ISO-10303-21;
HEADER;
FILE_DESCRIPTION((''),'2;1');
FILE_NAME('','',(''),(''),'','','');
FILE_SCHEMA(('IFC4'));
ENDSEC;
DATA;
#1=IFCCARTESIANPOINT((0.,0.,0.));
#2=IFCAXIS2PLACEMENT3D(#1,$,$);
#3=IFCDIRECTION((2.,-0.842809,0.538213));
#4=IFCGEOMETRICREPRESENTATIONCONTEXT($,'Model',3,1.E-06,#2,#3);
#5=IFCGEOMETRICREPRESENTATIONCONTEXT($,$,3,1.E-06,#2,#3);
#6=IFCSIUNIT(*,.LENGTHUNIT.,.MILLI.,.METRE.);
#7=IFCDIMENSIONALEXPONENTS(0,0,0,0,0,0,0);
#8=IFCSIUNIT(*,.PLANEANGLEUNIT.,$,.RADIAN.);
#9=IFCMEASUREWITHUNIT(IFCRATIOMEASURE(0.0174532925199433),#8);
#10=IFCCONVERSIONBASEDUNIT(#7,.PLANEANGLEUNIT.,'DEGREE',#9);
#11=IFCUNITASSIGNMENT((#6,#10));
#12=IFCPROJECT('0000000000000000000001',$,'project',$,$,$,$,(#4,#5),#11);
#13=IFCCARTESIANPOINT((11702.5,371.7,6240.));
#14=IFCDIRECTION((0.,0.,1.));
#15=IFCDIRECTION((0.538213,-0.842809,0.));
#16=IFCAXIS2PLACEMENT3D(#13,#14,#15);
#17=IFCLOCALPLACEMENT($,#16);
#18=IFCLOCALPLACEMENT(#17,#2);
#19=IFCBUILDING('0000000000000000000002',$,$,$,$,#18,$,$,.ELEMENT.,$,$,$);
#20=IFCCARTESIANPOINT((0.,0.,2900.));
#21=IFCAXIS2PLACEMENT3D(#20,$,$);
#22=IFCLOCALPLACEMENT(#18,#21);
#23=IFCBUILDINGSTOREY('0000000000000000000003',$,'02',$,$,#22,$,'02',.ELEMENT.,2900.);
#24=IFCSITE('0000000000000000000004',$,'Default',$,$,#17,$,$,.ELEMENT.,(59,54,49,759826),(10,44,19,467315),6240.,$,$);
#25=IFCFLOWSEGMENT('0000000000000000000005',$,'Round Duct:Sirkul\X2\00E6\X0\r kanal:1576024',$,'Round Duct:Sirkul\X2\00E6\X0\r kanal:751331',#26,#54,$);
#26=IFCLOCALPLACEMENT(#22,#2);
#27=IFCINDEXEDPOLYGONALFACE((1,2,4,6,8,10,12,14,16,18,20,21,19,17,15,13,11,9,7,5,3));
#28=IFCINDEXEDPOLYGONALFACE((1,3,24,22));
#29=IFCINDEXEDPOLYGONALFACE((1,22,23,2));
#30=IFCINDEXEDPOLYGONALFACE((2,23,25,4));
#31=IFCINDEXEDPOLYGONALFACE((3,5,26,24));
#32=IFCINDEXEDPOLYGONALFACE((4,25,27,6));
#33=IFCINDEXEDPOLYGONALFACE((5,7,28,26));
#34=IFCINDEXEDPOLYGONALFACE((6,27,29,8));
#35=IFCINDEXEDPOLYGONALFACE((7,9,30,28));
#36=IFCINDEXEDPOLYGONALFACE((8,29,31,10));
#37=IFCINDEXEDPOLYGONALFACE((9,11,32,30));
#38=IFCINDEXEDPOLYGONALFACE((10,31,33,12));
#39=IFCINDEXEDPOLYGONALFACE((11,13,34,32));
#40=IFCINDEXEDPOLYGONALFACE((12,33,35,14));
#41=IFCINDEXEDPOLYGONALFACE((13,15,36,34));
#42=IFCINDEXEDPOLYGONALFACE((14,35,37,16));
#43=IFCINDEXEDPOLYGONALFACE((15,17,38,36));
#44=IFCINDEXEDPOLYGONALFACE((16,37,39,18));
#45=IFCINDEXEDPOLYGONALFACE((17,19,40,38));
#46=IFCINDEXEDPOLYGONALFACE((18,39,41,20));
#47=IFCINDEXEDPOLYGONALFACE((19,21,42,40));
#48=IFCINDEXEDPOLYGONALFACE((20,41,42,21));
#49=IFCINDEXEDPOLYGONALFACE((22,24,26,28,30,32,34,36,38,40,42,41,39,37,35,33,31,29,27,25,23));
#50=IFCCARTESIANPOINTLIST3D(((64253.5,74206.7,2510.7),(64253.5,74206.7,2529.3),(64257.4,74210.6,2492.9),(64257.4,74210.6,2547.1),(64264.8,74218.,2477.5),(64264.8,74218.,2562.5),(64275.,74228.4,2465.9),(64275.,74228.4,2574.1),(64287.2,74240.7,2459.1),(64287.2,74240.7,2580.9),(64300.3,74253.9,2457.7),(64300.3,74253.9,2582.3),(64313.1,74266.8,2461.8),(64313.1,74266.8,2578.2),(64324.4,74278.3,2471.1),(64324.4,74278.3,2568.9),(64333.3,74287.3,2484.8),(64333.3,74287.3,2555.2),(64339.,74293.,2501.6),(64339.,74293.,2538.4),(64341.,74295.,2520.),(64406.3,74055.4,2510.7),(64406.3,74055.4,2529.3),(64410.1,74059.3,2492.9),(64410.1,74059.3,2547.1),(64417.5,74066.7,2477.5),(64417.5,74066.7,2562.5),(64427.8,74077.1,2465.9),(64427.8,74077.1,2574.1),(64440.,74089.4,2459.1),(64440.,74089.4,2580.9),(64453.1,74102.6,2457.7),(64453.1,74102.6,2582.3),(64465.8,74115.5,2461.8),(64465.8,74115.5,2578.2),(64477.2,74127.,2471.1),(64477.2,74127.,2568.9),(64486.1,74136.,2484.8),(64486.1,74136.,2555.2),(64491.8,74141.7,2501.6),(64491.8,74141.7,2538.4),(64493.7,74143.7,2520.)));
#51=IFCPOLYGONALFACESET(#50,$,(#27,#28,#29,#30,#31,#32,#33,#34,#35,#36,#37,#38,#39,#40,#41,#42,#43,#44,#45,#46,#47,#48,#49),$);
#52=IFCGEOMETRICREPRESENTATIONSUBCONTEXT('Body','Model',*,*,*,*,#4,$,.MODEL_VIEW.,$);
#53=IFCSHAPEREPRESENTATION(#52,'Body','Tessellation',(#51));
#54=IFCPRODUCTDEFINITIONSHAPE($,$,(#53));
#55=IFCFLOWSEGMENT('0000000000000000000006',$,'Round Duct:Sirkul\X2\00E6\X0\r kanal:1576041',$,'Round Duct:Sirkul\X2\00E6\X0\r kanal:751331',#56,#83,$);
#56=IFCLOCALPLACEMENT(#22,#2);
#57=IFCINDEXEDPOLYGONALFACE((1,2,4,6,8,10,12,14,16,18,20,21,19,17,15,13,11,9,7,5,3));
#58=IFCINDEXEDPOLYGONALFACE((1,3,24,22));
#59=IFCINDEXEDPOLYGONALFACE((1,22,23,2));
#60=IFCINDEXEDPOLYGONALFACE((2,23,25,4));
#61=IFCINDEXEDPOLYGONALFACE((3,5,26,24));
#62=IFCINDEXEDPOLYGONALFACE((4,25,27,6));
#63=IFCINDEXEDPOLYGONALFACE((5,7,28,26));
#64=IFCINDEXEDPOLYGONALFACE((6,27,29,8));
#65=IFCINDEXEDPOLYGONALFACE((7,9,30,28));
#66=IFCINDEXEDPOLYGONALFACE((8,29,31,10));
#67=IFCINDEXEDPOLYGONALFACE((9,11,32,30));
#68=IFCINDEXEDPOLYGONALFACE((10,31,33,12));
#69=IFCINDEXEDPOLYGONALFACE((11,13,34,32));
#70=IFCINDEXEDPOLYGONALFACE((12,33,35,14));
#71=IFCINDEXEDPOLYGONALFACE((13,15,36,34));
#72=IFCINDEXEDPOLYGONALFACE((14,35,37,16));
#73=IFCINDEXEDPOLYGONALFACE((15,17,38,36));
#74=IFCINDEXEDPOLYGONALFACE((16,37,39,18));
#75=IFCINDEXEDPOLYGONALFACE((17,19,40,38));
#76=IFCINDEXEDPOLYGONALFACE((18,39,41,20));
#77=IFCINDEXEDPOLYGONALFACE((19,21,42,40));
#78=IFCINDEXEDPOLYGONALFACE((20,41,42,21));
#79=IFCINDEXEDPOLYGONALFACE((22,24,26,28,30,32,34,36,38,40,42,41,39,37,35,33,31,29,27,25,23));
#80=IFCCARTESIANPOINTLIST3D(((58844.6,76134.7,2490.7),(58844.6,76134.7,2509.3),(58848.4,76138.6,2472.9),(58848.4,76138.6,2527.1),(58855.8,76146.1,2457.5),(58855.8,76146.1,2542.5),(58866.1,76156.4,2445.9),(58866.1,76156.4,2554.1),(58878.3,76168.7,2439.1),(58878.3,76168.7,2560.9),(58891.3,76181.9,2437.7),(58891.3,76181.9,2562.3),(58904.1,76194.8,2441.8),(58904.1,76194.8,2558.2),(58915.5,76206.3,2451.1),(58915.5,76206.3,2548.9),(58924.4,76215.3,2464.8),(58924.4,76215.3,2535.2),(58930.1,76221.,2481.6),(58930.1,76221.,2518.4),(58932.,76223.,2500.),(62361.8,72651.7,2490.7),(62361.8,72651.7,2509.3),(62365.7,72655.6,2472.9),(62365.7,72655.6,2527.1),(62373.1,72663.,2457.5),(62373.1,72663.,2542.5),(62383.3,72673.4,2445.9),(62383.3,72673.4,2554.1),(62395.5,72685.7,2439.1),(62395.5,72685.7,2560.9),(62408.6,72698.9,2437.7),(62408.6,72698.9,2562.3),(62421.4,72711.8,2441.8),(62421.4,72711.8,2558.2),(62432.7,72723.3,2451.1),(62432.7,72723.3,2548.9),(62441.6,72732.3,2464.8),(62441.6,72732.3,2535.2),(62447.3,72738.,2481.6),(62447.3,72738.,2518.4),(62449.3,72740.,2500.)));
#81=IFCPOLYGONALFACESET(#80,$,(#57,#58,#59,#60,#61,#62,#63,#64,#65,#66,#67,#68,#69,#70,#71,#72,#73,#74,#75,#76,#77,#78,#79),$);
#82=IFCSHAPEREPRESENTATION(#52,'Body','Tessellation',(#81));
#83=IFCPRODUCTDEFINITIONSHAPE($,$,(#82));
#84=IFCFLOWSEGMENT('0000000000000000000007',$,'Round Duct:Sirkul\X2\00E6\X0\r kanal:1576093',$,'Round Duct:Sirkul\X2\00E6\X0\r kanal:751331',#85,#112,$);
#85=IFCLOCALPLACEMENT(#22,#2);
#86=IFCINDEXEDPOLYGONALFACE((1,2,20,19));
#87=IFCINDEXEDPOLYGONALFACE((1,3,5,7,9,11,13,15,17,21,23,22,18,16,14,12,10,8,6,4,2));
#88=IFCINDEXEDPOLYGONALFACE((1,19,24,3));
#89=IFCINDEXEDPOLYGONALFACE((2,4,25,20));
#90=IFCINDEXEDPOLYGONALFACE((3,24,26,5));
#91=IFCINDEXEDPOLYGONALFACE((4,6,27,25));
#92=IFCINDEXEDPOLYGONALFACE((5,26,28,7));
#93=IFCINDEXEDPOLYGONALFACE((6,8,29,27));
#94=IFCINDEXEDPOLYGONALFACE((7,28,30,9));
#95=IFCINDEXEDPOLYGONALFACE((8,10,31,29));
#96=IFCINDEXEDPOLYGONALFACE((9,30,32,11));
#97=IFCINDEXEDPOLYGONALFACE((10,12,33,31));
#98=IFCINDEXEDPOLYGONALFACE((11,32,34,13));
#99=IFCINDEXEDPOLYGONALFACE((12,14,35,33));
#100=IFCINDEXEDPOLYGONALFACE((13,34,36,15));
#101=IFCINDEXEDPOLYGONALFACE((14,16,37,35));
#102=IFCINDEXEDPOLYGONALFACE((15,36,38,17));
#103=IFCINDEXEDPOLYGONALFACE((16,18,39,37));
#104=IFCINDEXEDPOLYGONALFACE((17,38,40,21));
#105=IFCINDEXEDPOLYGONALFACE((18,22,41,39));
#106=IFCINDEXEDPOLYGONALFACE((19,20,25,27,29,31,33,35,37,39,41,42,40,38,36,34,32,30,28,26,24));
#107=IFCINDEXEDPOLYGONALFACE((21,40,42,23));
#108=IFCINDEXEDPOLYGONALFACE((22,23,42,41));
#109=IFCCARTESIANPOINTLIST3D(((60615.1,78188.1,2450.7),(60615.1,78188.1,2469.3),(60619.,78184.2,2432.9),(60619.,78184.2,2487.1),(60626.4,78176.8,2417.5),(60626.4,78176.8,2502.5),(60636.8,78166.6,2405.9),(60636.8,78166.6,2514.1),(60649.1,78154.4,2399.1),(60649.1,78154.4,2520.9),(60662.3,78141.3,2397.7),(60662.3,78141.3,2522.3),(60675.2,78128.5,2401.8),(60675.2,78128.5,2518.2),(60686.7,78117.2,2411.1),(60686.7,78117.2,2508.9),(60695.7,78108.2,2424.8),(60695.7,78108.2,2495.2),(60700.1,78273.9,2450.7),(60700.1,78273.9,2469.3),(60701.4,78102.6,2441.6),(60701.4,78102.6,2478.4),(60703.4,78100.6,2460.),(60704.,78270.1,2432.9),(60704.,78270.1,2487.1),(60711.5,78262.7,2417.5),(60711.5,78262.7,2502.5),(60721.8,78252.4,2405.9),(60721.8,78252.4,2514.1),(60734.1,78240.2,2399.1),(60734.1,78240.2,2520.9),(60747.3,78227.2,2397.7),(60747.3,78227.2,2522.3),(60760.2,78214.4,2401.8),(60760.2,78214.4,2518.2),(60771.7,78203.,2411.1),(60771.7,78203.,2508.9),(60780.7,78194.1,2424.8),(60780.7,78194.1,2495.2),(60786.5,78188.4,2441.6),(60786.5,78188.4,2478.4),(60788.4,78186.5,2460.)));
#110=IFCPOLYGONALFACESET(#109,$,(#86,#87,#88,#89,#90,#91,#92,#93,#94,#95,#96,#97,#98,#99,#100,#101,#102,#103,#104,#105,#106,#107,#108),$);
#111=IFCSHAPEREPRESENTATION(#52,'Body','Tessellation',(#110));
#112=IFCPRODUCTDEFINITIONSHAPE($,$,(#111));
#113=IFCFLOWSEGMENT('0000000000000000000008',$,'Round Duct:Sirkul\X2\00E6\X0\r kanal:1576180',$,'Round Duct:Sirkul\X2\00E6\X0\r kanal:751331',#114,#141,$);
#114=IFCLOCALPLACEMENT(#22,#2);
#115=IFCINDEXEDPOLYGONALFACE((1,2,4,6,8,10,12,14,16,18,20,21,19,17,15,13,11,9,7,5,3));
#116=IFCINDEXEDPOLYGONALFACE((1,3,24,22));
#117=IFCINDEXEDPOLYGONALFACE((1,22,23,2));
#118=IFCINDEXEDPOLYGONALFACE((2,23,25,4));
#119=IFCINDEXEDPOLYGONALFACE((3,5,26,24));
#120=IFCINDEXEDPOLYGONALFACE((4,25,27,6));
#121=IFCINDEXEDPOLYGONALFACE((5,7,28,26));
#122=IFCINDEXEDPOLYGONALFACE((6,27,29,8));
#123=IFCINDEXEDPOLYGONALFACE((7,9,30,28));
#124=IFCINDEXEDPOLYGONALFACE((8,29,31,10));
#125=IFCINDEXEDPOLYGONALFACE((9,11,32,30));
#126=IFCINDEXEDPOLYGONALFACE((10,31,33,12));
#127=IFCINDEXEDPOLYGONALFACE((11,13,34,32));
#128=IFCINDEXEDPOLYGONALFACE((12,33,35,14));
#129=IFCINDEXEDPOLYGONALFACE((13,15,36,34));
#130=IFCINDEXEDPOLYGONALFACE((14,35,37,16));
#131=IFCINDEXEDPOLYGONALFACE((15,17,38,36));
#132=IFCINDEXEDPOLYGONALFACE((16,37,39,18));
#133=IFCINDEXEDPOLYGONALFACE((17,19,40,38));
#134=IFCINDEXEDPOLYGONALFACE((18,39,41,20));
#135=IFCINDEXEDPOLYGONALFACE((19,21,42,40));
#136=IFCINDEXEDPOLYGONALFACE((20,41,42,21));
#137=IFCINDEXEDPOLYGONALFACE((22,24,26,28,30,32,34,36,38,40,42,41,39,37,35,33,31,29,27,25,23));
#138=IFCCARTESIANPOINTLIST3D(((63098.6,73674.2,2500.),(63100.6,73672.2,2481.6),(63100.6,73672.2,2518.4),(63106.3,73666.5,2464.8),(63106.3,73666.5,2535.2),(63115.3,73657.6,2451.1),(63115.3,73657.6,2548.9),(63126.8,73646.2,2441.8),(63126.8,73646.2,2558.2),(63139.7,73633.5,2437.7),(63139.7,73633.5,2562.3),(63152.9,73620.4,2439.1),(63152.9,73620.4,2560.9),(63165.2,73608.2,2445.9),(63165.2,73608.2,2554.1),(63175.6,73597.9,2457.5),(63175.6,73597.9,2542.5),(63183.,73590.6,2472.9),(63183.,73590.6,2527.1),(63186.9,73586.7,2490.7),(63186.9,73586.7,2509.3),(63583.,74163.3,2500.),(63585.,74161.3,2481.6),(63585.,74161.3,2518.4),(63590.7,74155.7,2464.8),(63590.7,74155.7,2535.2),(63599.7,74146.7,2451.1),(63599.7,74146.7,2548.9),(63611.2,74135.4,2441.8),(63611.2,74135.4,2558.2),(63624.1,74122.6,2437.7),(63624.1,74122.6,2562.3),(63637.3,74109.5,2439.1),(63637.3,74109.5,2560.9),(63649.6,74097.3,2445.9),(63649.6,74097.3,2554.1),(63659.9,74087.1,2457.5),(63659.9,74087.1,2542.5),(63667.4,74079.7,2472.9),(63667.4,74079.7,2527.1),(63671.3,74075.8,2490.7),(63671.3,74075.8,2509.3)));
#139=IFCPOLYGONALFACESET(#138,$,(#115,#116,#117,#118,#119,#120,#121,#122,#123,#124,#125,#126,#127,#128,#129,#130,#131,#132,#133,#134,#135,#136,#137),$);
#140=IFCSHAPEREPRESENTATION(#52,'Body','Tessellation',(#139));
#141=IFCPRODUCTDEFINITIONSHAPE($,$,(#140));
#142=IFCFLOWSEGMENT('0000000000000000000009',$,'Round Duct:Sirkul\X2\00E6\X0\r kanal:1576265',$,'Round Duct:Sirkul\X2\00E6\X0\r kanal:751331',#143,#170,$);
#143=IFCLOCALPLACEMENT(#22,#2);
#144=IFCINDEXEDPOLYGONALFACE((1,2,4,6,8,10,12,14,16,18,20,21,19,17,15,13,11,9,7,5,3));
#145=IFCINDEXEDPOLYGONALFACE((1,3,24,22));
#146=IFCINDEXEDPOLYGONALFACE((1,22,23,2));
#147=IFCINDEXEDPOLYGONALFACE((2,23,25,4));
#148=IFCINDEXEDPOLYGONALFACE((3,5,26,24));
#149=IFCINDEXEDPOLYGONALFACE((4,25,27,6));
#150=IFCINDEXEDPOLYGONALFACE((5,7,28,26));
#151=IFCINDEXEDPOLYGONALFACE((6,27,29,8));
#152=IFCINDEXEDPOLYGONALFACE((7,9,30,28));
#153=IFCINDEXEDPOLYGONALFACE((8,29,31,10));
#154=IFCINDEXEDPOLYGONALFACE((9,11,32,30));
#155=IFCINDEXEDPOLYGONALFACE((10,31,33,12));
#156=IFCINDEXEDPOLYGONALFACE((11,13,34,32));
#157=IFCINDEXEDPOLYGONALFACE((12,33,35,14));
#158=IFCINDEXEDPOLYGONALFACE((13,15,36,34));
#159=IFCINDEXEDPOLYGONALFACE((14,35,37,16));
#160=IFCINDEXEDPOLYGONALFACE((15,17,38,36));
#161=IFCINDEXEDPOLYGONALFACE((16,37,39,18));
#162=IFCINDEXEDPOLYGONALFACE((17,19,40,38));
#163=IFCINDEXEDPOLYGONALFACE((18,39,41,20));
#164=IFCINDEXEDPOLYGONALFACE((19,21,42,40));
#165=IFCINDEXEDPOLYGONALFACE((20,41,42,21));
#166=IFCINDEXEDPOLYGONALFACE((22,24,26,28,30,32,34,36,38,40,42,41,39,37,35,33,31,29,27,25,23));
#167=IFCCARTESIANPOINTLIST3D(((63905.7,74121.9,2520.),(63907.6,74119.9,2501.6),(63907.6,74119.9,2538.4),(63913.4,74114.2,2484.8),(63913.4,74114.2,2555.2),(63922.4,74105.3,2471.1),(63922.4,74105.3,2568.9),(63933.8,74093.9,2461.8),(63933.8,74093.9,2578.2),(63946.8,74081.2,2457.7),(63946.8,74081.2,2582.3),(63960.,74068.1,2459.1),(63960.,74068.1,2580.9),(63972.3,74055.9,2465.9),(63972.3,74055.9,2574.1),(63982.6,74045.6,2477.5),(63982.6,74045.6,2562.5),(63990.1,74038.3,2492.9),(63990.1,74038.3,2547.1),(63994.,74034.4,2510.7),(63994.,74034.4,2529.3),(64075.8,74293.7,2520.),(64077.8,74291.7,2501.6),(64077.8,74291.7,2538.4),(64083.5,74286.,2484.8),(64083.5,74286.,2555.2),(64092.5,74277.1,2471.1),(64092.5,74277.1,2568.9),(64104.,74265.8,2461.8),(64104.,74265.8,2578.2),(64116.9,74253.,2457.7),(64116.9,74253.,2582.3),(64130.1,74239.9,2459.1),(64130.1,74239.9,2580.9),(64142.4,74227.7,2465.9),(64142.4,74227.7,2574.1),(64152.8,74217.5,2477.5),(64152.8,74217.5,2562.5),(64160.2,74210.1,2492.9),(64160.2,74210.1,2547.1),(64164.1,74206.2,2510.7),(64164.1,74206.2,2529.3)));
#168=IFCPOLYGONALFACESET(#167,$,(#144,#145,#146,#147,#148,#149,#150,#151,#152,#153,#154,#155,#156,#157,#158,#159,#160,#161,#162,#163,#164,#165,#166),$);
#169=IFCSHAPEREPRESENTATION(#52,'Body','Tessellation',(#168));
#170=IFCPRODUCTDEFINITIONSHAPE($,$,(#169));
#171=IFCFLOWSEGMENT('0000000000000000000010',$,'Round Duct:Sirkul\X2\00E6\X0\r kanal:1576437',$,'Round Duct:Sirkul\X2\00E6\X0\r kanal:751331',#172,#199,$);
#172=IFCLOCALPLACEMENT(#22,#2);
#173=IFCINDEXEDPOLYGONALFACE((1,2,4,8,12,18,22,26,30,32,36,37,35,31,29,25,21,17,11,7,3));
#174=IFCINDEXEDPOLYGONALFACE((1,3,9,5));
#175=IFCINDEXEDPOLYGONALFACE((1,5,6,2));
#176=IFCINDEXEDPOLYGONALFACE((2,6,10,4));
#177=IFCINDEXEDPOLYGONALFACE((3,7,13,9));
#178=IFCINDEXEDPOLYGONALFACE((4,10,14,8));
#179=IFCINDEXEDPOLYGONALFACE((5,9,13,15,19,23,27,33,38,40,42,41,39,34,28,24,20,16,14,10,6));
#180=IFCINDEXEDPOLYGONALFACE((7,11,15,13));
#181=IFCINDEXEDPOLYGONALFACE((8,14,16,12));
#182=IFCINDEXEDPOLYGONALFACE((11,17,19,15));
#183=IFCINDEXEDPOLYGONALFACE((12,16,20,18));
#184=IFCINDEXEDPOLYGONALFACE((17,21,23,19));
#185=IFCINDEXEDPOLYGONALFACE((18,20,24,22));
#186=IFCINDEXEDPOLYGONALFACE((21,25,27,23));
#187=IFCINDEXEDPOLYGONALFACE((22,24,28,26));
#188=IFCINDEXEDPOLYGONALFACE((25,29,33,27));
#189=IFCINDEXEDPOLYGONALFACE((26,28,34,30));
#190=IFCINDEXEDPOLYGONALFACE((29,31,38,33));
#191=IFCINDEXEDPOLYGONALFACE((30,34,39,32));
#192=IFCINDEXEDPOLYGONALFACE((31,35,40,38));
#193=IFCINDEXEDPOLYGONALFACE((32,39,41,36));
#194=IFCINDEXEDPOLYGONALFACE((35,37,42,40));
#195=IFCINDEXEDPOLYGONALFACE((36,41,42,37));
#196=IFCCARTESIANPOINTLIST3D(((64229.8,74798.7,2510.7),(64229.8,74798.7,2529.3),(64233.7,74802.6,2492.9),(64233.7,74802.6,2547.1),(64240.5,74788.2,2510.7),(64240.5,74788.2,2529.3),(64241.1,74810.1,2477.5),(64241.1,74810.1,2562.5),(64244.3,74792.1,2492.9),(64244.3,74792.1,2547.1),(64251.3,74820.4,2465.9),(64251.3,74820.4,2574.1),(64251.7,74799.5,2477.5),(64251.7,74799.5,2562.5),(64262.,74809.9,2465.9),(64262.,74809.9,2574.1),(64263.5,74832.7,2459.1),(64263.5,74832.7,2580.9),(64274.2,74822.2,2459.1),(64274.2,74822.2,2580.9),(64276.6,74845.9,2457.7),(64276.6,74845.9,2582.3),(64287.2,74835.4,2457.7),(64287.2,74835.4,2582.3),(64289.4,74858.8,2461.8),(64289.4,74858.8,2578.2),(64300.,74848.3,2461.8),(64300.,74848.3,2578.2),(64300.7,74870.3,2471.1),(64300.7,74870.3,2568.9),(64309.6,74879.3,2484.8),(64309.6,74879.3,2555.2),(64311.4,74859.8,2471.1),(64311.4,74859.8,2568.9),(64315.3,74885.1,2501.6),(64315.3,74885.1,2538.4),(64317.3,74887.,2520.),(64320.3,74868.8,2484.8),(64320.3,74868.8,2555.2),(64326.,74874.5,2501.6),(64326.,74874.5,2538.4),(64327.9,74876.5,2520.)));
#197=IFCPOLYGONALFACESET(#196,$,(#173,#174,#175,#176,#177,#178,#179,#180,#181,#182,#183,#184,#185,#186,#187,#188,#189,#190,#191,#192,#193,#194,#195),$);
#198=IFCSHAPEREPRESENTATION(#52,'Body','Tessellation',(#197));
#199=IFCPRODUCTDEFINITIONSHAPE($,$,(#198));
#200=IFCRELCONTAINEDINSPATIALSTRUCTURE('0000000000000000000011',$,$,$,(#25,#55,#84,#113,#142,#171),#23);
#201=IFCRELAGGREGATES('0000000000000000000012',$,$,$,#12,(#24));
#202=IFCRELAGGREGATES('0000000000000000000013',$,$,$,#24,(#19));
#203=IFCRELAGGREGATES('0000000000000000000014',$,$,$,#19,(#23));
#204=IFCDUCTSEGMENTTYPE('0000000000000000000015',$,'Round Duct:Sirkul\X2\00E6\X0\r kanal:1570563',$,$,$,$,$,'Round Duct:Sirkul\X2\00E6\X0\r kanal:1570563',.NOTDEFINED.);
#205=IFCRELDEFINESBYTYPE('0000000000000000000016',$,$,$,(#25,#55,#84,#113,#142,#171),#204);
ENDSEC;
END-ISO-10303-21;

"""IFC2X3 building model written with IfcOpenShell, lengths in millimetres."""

from ifc_helpers import new_model, entity, si_unit, converted_unit, direction, frame, origin, origin_2d_with_axis, place, context, subcontext, project, spatial, circle, extrude, type_object, element, save


model = new_model("IFC2X3")

# Units and contexts
model_context = context("Model", 3, precision=1e-06, world=origin(), true_north=direction((2.0, -0.842809, 0.538213)))
context_of_model = context(None, 3, precision=1e-06, world=origin(), true_north=direction((2.0, -0.842809, 0.538213)))
body_context = subcontext(model_context, "Body", "Model", "MODEL_VIEW")
ifc_project = project(units=[si_unit("LENGTHUNIT", "METRE", prefix="MILLI"), converted_unit("PLANEANGLEUNIT", "DEGREE", entity("IfcRatioMeasure", 0.0174532925199433), si_unit("PLANEANGLEUNIT", "RADIAN"), dimensions=[0, 0, 0, 0, 0, 0, 0])], contexts=[model_context, context_of_model])

# Site, building, storey
site_placement = place(None, frame((11702.5, 371.7, 6240.0), z_axis=(0.0, 0.0, 1.0), x_axis=(0.538213, -0.842809, 0.0)))
site = spatial("IfcSite", under=ifc_project, at=site_placement, Name="Default", CompositionType="ELEMENT", RefLatitude=(59, 54, 49, 759826), RefLongitude=(10, 44, 19, 467315), RefElevation=6240.0)
building_placement = place(site_placement, origin())
building = spatial("IfcBuilding", under=site, at=building_placement, CompositionType="ELEMENT")
storey_placement = place(building_placement, frame((0.0, 0.0, 2900.0)))
storey = spatial("IfcBuildingStorey", under=building, at=storey_placement, Name="02", LongName="02", CompositionType="ELEMENT", Elevation=2900.0)

# Flow segments
duct_segment_type = type_object("IfcDuctSegmentType", Name="Round Duct:Sirkulær kanal:1570563", ElementType="Round Duct:Sirkulær kanal:1570563", PredefinedType="NOTDEFINED")
flow_segment_1_placement = place(storey_placement, origin())
element("IfcFlowSegment", 1, at=flow_segment_1_placement, inside=storey, type_object=duct_segment_type, Name="Round Duct:Sirkulær kanal:1576024", ObjectType="Round Duct:Sirkulær kanal:751331", context=body_context, shape_type="SweptSolid", body=[
    extrude(circle(Radius=62.5, at=origin_2d_with_axis()), frame((64449.8, 74099.3, 2520.0), z_axis=(-0.710554, 0.703643, 0.0), x_axis=(0.703643, 0.710554, 0.0)), (0.0, 0.0, 1.0), 215.0),
])
flow_segment_2_placement = place(storey_placement, origin())
element("IfcFlowSegment", 2, at=flow_segment_2_placement, inside=storey, type_object=duct_segment_type, Name="Round Duct:Sirkulær kanal:1576041", ObjectType="Round Duct:Sirkulær kanal:751331", context=body_context, shape_type="SweptSolid", body=[
    extrude(circle(Radius=62.5, at=origin_2d_with_axis()), frame((62405.3, 72695.6, 2500.0), z_axis=(-0.710554, 0.703643, 0.0), x_axis=(0.703643, 0.710554, 0.0)), (0.0, 0.0, 1.0), 4950.0),
])
flow_segment_3_placement = place(storey_placement, origin())
element("IfcFlowSegment", 3, at=flow_segment_3_placement, inside=storey, type_object=duct_segment_type, Name="Round Duct:Sirkulær kanal:1576093", ObjectType="Round Duct:Sirkulær kanal:751331", context=body_context, shape_type="SweptSolid", body=[
    extrude(circle(Radius=62.5, at=origin_2d_with_axis()), frame((60659.0, 78144.6, 2460.0), z_axis=(0.703644, 0.710553, 0.0), x_axis=(0.710553, -0.703644, 0.0)), (0.0, 0.0, 1.0), 120.8),
])
flow_segment_4_placement = place(storey_placement, origin())
element("IfcFlowSegment", 4, at=flow_segment_4_placement, inside=storey, type_object=duct_segment_type, Name="Round Duct:Sirkulær kanal:1576180", ObjectType="Round Duct:Sirkulær kanal:751331", context=body_context, shape_type="SweptSolid", body=[
    extrude(circle(Radius=62.5, at=origin_2d_with_axis()), frame((63143.0, 73630.2, 2500.0), z_axis=(0.703643, 0.710554, 0.0), x_axis=(-0.710554, 0.703643, 0.0)), (0.0, 0.0, 1.0), 688.4),
])
flow_segment_5_placement = place(storey_placement, origin())
element("IfcFlowSegment", 5, at=flow_segment_5_placement, inside=storey, type_object=duct_segment_type, Name="Round Duct:Sirkulær kanal:1576265", ObjectType="Round Duct:Sirkulær kanal:751331", context=body_context, shape_type="SweptSolid", body=[
    extrude(circle(Radius=62.5, at=origin_2d_with_axis()), frame((63950.1, 74077.9, 2520.0), z_axis=(0.703643, 0.710554, 0.0), x_axis=(-0.710554, 0.703643, 0.0)), (0.0, 0.0, 1.0), 241.8),
])
flow_segment_6_placement = place(storey_placement, origin())
element("IfcFlowSegment", 6, at=flow_segment_6_placement, inside=storey, type_object=duct_segment_type, Name="Round Duct:Sirkulær kanal:1576437", ObjectType="Round Duct:Sirkulær kanal:751331", context=body_context, shape_type="SweptSolid", body=[
    extrude(circle(Radius=62.5, at=origin_2d_with_axis()), frame((64284.0, 74832.1, 2520.0), z_axis=(-0.710554, 0.703643, 0.0), x_axis=(0.703643, 0.710554, 0.0)), (0.0, 0.0, 1.0), 15.0),
])

save(model, "model.ifc")
